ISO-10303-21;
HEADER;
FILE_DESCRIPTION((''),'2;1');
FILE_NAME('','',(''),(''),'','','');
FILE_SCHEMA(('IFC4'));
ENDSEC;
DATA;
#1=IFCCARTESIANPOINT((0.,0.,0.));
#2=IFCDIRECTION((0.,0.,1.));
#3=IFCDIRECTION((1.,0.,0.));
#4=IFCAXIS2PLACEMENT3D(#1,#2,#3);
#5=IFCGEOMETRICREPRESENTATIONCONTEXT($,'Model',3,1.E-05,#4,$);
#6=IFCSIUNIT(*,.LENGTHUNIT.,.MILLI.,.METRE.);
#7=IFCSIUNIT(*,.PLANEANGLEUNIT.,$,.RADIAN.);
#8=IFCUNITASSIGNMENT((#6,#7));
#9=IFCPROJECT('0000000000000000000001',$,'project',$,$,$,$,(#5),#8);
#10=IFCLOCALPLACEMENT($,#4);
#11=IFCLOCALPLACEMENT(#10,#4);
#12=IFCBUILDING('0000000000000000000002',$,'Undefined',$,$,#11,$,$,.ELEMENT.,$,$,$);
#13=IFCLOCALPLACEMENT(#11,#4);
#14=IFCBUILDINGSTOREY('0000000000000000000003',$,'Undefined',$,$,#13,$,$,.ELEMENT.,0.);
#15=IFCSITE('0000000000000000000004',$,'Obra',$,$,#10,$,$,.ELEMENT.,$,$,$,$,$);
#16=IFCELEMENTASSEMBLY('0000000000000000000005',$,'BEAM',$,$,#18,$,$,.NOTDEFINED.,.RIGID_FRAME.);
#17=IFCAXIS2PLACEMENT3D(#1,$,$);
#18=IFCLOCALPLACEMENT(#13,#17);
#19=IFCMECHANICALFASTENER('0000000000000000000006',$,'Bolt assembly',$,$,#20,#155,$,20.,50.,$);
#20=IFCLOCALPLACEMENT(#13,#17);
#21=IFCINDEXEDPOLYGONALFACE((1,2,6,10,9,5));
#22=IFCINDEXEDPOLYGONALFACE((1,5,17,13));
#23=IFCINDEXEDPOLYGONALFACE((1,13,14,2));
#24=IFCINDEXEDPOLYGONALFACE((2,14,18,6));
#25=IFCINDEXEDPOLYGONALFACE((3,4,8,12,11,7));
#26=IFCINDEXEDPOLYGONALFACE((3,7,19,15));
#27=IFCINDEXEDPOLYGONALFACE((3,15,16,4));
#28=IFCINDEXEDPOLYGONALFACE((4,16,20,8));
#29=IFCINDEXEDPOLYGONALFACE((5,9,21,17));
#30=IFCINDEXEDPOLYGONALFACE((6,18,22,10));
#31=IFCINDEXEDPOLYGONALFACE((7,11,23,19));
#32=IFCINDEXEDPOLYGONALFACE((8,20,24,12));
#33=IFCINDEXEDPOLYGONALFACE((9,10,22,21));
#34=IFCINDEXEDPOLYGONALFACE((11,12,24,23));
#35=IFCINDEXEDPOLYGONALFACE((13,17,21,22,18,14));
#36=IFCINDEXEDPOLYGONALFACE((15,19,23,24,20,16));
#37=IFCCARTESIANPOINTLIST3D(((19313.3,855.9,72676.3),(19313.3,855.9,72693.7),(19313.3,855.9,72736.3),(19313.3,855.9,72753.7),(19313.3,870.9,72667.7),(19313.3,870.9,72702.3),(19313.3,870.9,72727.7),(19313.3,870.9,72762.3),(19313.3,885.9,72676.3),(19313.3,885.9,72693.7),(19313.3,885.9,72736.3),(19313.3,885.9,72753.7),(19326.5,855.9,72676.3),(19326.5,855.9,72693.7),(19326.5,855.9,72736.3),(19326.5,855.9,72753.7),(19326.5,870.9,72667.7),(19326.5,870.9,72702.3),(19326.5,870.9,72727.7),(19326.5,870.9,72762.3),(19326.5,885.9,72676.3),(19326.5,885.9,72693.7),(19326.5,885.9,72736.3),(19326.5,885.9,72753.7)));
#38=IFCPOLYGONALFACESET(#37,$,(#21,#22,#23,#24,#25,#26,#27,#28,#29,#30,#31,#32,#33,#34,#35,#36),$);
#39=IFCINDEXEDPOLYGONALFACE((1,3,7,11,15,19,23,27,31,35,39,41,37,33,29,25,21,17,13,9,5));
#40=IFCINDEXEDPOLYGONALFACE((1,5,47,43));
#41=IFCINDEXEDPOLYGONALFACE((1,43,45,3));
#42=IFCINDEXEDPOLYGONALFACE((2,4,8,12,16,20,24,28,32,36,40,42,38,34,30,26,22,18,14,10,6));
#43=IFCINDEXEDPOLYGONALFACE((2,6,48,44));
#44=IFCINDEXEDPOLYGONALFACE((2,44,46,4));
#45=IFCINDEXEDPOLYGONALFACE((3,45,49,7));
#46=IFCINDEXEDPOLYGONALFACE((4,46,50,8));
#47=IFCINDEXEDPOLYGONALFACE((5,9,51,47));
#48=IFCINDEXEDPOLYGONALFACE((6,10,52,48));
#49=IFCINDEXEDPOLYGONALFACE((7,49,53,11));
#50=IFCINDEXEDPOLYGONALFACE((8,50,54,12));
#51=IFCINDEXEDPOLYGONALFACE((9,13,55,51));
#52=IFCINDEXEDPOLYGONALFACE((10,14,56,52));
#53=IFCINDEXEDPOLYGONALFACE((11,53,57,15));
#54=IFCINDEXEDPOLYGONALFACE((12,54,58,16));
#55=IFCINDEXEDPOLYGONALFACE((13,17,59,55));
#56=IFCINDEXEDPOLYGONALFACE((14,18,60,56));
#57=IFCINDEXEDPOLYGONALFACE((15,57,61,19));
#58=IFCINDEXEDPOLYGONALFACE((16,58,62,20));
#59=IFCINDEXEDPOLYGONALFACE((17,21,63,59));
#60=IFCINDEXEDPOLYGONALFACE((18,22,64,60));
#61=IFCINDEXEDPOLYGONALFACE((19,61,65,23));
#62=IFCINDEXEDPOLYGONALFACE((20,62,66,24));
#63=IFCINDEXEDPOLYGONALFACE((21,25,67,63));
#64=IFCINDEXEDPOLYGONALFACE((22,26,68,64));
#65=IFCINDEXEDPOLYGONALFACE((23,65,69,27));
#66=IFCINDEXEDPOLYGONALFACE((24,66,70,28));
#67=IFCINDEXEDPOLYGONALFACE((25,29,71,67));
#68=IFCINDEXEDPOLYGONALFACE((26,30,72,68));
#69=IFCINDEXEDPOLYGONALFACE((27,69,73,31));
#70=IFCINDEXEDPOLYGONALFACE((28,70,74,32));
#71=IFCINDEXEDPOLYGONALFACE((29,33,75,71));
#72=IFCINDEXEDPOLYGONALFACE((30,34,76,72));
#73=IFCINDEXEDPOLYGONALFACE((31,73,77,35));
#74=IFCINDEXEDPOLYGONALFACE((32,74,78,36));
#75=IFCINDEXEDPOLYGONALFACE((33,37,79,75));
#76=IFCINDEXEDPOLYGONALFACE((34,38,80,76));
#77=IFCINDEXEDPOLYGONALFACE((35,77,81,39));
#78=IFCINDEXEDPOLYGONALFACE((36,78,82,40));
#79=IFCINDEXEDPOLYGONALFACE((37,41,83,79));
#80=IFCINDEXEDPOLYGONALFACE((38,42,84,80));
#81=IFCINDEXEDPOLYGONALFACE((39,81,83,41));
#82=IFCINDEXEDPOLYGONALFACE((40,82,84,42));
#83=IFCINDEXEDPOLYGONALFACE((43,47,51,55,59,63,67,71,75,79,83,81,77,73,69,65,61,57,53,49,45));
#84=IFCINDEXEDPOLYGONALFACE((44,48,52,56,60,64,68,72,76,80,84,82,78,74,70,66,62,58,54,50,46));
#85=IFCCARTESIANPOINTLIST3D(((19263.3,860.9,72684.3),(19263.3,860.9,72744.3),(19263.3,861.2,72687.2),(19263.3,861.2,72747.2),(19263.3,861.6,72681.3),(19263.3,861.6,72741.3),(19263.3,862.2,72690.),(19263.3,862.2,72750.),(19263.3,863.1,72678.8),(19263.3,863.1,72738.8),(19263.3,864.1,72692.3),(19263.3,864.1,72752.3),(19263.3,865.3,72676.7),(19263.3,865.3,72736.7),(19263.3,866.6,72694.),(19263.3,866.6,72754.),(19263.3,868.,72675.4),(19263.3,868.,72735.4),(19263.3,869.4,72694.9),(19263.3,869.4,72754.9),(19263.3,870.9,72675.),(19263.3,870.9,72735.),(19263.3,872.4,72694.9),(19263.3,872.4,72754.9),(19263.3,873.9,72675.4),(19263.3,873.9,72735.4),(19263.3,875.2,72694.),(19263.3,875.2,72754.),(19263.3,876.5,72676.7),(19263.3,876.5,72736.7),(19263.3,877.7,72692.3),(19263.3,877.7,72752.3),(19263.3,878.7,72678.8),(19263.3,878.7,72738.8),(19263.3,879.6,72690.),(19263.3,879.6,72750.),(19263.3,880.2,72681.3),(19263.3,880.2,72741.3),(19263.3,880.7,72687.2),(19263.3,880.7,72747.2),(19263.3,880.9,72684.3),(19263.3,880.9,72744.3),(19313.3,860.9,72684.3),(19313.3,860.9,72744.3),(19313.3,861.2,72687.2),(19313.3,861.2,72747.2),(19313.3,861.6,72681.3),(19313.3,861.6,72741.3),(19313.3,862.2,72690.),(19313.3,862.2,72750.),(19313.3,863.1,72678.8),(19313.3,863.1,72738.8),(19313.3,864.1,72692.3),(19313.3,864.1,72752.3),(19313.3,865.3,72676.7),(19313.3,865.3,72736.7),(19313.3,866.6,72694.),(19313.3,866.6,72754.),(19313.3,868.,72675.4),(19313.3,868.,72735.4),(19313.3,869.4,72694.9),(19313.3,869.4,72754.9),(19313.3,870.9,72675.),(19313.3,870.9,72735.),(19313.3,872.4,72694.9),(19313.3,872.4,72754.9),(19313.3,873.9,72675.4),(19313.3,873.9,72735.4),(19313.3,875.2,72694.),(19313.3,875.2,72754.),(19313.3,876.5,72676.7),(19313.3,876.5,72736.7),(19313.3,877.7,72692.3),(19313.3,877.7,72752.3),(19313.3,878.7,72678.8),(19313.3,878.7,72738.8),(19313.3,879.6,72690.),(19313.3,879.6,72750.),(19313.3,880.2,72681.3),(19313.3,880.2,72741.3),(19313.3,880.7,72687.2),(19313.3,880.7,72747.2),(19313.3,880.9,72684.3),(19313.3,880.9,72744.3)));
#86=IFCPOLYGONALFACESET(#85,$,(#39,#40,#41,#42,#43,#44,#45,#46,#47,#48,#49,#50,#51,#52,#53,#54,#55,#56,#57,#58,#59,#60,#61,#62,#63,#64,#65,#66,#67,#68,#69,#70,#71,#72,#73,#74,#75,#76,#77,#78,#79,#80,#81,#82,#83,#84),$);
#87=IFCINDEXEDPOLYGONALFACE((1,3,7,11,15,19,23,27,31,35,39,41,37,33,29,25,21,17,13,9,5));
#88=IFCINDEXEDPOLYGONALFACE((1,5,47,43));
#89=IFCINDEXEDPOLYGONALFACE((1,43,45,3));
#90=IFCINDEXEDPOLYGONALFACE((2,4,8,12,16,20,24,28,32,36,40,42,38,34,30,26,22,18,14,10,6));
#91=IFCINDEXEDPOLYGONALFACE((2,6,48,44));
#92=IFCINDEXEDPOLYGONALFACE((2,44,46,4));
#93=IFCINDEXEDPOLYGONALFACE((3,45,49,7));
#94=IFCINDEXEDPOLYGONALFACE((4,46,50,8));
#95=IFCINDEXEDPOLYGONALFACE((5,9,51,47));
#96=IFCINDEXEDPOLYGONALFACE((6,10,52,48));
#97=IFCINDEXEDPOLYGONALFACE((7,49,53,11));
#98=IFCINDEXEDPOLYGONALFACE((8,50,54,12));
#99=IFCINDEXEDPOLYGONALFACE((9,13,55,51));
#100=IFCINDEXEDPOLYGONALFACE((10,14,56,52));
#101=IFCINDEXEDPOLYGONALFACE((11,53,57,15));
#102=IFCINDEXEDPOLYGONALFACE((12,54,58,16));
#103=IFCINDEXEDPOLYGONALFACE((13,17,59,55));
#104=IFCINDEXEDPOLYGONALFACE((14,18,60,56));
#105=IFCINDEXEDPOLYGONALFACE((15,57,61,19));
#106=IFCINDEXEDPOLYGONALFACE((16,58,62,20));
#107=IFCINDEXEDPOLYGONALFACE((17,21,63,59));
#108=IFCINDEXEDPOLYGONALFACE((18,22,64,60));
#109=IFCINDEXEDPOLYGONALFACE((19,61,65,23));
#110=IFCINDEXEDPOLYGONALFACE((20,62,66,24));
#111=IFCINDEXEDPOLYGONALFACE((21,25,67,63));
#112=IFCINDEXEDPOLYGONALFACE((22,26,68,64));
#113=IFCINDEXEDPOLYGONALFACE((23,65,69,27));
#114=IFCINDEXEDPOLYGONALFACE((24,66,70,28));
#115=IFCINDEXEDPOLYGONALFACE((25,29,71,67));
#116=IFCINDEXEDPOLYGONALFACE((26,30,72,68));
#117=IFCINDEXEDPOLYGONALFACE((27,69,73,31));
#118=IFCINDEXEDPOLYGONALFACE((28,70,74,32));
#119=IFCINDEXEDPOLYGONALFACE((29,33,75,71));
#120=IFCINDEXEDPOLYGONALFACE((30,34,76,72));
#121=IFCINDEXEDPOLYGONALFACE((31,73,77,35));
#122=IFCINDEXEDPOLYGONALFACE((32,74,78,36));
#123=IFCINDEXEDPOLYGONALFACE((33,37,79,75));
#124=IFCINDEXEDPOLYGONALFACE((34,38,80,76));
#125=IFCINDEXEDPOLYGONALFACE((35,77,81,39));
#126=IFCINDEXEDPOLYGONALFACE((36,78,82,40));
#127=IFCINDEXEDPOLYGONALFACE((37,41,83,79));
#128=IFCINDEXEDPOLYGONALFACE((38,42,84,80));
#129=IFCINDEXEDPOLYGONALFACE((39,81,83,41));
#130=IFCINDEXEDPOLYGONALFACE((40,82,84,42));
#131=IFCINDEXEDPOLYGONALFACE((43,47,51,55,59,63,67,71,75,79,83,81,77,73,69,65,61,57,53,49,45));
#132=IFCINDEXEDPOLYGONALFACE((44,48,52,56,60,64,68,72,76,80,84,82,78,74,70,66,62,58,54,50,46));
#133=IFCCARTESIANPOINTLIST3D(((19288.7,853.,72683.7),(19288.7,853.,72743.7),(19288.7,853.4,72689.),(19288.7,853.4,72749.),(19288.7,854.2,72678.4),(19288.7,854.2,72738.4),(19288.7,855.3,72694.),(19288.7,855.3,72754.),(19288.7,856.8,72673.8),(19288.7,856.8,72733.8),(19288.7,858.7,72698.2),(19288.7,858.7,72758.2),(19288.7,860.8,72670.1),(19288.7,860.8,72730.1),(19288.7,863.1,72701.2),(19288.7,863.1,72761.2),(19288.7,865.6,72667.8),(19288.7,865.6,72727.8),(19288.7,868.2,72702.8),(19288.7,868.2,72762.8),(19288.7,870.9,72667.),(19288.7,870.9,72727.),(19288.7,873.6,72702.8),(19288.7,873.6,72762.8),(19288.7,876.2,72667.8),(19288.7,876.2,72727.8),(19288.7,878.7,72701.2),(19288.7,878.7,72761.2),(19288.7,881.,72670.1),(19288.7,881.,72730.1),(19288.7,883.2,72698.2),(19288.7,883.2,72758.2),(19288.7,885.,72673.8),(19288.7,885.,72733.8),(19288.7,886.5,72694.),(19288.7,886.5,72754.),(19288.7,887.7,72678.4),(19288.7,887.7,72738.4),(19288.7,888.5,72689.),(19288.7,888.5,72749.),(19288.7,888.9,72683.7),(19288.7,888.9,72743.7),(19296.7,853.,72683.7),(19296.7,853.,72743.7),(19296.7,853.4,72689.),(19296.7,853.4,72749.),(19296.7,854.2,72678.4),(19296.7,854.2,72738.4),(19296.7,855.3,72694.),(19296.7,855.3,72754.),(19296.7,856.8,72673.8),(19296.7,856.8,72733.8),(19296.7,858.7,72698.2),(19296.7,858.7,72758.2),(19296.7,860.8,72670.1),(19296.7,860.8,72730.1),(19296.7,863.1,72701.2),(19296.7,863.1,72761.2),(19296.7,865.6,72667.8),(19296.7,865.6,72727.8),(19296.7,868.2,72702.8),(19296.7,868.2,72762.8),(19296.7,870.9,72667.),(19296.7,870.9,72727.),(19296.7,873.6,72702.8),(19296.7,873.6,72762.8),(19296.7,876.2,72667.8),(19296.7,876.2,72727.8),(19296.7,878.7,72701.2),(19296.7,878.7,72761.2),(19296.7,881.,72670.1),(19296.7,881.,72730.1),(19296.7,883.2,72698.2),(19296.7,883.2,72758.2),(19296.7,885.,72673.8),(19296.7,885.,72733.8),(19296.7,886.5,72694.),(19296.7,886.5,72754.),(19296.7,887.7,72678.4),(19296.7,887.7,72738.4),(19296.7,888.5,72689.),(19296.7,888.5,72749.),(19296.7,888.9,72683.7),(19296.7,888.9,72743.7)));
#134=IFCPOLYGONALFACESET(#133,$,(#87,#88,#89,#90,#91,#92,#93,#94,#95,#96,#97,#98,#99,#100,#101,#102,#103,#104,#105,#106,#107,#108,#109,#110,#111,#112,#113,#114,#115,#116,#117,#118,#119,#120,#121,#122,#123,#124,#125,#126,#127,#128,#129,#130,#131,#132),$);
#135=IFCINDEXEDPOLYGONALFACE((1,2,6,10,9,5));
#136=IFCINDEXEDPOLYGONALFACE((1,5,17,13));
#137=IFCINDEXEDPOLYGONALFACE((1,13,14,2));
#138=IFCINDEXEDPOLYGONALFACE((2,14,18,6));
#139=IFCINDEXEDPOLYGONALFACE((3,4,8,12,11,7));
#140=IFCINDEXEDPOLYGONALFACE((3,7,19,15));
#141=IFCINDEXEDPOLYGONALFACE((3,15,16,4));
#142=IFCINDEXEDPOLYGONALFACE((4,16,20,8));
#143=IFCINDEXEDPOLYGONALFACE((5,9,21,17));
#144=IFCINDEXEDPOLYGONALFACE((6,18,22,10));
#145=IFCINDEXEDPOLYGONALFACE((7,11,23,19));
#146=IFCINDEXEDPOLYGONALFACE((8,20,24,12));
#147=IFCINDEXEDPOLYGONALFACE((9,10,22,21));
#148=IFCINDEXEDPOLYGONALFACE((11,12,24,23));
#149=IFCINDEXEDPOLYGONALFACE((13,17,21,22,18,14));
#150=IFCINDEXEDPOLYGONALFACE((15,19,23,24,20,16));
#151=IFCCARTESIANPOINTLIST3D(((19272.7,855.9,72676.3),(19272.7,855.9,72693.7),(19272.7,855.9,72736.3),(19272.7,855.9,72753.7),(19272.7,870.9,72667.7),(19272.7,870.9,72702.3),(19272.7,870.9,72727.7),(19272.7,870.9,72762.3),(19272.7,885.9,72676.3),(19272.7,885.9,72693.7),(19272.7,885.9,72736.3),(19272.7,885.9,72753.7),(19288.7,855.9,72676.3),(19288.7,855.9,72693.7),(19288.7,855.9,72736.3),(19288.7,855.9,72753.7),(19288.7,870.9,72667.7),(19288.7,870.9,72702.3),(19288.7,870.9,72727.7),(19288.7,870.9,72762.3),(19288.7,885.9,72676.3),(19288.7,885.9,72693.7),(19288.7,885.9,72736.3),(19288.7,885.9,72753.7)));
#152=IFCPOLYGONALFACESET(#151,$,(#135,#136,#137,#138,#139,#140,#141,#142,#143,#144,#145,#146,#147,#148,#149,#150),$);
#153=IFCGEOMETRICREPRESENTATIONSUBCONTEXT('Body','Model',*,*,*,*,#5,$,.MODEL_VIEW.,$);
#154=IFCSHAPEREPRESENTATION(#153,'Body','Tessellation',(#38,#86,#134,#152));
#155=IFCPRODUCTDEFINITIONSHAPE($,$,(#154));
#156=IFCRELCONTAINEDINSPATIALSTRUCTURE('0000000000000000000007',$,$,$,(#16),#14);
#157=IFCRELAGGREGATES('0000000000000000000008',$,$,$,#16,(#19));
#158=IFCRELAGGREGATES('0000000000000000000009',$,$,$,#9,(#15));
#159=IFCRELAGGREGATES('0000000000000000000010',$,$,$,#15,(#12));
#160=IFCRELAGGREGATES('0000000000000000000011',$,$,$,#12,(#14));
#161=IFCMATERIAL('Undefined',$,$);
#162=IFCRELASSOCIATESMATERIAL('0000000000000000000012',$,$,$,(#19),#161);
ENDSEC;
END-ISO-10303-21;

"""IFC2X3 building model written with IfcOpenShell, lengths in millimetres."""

from ifc_helpers import new_model, si_unit, frame, origin_with_axes, origin_2d_with_axis, place, context, subcontext, project, spatial, polyline, circle, outline, extrude, source, transform, mapped, material, element, aggregate, save


model = new_model("IFC2X3")

# Units and contexts
model_context = context("Model", 3, precision=1e-05, world=origin_with_axes())
body_context = subcontext(model_context, "Body", "Model", "MODEL_VIEW")
ifc_project = project(units=[si_unit("LENGTHUNIT", "METRE", prefix="MILLI"), si_unit("PLANEANGLEUNIT", "RADIAN")], contexts=[model_context])

# Site, building, storey
site_placement = place(None, origin_with_axes())
site = spatial("IfcSite", under=ifc_project, at=site_placement, Name="Obra", CompositionType="ELEMENT")
building_placement = place(site_placement, origin_with_axes())
building = spatial("IfcBuilding", under=site, at=building_placement, Name="Undefined", CompositionType="ELEMENT")
storey_placement = place(building_placement, origin_with_axes())
storey = spatial("IfcBuildingStorey", under=building, at=storey_placement, Name="Undefined", CompositionType="ELEMENT", Elevation=0.0)

# Shared definitions
ifc_material = material(Name="Undefined")

# Shared definitions
shared_shape_1 = source(origin_with_axes(), body_context, "Body", "SweptSolid", [
    extrude(outline(polyline([(17.3, 0.0), (8.7, 15.0), (-8.7, 15.0), (-17.3, 0.0), (-8.7, -15.0), (8.7, -15.0), (17.3, 0.0)])), frame((0.0, -26.5, 0.0), z_axis=(0.0, 1.0, 0.0), x_axis=(1.0, 0.0, 0.0)), (0.0, 0.0, 1.0), 13.2),
    extrude(circle(Radius=10.0, at=origin_2d_with_axis()), frame((0.0, -13.3, 0.0), z_axis=(0.0, 1.0, 0.0), x_axis=(1.0, 0.0, 0.0)), (0.0, 0.0, 1.0), 50.0),
    extrude(circle(Radius=18.0, at=origin_2d_with_axis()), frame((0.0, 3.3, 0.0), z_axis=(0.0, 1.0, 0.0), x_axis=(1.0, 0.0, 0.0)), (0.0, 0.0, 1.0), 8.0),
    extrude(outline(polyline([(17.3, 0.0), (8.7, 15.0), (-8.7, 15.0), (-17.3, 0.0), (-8.7, -15.0), (8.7, -15.0), (17.3, 0.0)])), frame((0.0, 11.3, 0.0), z_axis=(0.0, 1.0, 0.0), x_axis=(1.0, 0.0, 0.0)), (0.0, 0.0, 1.0), 16.0),
])

# Element assembly, mechanical fastener
assembly_1_placement = place(storey_placement, origin_with_axes())
assembly_1 = element("IfcElementAssembly", 1, at=assembly_1_placement, inside=storey, Name="BEAM", AssemblyPlace="NOTDEFINED", PredefinedType="RIGID_FRAME")
mechanical_fastener_1_placement = place(assembly_1_placement, frame((19300.0, 830.9, 72850.0), z_axis=(0.0, 1.0, 0.0), x_axis=(0.0, 0.0, -1.0)))
mechanical_fastener_1 = element("IfcMechanicalFastener", 2, at=mechanical_fastener_1_placement, material=ifc_material, Name="Bolt assembly", NominalDiameter=20.0, NominalLength=50.0, context=body_context, shape_type="MappedRepresentation", body=[
    mapped(shared_shape_1, transform((105.0, 0.0, 40.0))),
    mapped(shared_shape_1, transform((165.0, 0.0, 40.0))),
])
aggregate(assembly_1, [mechanical_fastener_1])

save(model, "model.ifc")
